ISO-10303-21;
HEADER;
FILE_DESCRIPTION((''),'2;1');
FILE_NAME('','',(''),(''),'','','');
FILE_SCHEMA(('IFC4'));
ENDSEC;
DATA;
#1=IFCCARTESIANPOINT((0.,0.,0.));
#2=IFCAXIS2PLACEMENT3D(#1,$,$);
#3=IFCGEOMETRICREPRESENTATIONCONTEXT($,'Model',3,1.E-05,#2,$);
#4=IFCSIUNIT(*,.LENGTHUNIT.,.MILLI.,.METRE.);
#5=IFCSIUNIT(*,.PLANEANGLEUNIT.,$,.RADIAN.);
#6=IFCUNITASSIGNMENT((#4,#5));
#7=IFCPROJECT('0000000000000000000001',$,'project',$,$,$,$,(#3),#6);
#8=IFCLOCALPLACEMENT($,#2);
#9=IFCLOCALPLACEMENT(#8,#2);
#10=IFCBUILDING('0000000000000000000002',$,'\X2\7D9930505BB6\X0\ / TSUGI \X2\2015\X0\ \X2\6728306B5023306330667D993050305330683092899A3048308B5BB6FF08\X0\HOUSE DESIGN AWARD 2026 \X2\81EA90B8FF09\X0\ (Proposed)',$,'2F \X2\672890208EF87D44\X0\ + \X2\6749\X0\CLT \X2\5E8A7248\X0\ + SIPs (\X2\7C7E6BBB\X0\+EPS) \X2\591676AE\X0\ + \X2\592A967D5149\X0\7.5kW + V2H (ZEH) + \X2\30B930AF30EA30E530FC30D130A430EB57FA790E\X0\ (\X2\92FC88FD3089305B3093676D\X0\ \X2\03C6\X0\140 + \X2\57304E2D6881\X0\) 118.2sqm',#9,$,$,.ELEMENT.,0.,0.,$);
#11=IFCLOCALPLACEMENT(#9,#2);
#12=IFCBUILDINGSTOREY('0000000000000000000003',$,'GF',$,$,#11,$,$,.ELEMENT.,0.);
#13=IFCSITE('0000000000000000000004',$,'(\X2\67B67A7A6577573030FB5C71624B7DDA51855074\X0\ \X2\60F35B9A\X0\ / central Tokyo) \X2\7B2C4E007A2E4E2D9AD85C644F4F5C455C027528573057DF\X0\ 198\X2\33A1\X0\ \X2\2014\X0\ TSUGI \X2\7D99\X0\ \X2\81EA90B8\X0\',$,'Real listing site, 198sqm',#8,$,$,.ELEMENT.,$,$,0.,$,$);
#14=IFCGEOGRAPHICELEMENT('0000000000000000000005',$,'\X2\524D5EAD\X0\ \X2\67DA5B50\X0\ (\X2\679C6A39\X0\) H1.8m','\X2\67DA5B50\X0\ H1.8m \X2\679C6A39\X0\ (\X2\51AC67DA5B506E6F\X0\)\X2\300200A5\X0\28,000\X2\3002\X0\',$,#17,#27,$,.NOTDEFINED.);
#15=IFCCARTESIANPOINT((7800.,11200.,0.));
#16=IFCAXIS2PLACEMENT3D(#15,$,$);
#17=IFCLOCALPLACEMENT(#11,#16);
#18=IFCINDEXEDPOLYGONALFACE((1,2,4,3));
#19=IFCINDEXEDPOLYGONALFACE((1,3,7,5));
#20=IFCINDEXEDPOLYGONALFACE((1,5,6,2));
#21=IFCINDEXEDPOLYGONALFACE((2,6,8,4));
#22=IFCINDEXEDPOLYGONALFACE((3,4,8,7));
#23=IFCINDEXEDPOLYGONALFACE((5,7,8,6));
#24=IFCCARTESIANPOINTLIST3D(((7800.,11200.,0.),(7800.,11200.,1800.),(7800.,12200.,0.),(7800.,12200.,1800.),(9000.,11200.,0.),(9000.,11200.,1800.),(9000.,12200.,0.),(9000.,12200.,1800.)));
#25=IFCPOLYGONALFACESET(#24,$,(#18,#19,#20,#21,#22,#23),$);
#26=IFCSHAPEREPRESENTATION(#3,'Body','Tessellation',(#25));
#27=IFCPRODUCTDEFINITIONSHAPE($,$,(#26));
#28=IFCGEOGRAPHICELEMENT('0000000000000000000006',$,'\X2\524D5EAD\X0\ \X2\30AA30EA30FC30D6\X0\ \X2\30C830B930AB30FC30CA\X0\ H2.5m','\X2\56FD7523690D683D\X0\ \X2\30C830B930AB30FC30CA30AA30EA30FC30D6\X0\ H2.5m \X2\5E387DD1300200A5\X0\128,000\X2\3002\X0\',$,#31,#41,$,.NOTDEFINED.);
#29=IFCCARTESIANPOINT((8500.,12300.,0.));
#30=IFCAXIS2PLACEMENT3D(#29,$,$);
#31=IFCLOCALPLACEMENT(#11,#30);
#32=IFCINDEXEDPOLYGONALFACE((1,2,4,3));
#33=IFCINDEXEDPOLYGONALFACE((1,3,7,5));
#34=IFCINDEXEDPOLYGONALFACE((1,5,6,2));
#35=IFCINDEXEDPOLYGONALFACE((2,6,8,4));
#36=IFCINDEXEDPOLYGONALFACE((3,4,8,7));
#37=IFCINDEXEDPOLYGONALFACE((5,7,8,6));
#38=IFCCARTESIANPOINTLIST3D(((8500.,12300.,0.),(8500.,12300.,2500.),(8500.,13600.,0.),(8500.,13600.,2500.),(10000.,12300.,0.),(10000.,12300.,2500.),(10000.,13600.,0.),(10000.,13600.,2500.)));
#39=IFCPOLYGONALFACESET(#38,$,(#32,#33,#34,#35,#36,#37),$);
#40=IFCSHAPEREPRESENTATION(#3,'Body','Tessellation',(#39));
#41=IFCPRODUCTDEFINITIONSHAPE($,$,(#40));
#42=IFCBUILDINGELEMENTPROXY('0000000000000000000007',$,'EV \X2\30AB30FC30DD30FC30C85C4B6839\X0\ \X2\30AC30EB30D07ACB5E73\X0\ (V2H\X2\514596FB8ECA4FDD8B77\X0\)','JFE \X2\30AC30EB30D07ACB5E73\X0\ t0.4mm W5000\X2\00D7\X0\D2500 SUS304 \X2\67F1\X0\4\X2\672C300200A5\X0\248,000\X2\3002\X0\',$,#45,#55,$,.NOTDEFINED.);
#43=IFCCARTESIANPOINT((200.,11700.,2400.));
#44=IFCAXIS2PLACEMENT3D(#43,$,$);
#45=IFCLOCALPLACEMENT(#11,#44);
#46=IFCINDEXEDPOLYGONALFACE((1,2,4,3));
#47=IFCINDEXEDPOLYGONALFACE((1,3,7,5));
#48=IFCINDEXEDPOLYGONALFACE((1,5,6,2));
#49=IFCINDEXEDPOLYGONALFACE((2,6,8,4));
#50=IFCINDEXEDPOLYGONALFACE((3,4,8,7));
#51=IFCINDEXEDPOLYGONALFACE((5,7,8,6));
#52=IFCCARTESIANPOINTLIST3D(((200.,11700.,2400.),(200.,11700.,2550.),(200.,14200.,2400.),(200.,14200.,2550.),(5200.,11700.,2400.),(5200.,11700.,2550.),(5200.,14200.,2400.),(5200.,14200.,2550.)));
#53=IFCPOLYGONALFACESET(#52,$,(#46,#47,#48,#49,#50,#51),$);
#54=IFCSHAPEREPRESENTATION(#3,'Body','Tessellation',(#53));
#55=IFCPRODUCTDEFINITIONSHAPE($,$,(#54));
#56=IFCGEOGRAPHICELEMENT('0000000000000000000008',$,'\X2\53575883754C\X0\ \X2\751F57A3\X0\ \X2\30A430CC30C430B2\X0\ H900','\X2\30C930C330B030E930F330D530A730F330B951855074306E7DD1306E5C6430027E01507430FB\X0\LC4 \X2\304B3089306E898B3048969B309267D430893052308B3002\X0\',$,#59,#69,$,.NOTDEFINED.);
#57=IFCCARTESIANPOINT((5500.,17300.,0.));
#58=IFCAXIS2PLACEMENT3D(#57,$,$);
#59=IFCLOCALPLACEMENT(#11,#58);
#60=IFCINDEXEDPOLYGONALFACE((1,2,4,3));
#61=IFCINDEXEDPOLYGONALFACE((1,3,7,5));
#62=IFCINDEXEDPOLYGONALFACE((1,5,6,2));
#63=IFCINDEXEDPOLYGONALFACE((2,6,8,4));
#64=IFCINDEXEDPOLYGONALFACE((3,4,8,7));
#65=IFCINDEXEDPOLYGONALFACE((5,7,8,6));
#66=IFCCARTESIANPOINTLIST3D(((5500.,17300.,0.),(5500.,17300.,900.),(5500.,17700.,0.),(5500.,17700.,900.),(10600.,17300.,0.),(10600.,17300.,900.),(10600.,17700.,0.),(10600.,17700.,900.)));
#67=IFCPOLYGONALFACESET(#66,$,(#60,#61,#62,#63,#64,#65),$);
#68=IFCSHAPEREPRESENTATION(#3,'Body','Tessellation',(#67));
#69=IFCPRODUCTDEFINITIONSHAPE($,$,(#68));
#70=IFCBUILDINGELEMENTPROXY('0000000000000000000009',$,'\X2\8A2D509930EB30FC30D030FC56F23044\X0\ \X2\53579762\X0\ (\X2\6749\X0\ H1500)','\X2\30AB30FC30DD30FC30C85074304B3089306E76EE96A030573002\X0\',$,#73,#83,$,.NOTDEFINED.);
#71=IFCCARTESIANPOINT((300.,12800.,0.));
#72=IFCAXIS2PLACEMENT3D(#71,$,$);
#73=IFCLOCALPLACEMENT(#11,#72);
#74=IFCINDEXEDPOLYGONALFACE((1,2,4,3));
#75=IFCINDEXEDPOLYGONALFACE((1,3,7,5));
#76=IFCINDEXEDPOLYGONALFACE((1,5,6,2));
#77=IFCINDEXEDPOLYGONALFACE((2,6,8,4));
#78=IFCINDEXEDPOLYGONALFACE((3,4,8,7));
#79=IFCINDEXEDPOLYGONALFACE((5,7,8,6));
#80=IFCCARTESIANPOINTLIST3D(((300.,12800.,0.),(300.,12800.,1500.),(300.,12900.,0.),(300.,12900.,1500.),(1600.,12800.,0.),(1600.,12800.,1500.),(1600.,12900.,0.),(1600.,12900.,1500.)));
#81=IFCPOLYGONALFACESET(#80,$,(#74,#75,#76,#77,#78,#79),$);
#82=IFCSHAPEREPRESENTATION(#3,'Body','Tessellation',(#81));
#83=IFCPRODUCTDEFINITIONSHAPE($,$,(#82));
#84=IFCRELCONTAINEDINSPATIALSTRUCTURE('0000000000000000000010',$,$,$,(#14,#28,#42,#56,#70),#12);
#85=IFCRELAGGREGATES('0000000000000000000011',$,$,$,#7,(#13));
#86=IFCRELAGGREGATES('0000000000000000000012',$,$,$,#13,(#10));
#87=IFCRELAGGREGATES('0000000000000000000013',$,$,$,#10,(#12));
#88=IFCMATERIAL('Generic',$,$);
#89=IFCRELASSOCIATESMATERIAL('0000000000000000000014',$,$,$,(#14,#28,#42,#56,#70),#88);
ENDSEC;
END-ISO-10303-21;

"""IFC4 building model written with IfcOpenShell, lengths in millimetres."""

from ifc_helpers import new_model, si_unit, frame, frame_2d, origin, place, context, project, spatial, rectangle, extrude, material, element, save


model = new_model("IFC4")

# Units and contexts
model_context = context("Model", 3, precision=1e-05, world=origin())
ifc_project = project(units=[si_unit("LENGTHUNIT", "METRE", prefix="MILLI"), si_unit("PLANEANGLEUNIT", "RADIAN")], contexts=[model_context])

# Site, building, storey
site_placement = place(None, origin())
site = spatial("IfcSite", under=ifc_project, at=site_placement, Name="(架空敷地・山手線内側 想定 / central Tokyo) 第一種中高層住居専用地域 198㎡ — TSUGI 継 自邸", ObjectType="Real listing site, 198sqm", CompositionType="ELEMENT", RefElevation=0.0)
building_placement = place(site_placement, origin())
building = spatial("IfcBuilding", under=site, at=building_placement, Name="継ぐ家 / TSUGI ― 木に倣って継ぐことを覚える家（HOUSE DESIGN AWARD 2026 自邸） (Proposed)", ObjectType="2F 木造軸組 + 杉CLT 床版 + SIPs (籾殻+EPS) 外皮 + 太陽光7.5kW + V2H (ZEH) + スクリューパイル基礎 (鋼製らせん杭 φ140 + 地中梁) 118.2sqm", CompositionType="ELEMENT", ElevationOfRefHeight=0.0, ElevationOfTerrain=0.0)
storey_placement = place(building_placement, origin())
storey = spatial("IfcBuildingStorey", under=building, at=storey_placement, Name="GF", CompositionType="ELEMENT", Elevation=0.0)

# Shared definitions
ifc_material_1 = material(Name="Generic")

# Geographic elements
geographic_element_1_placement = place(storey_placement, frame((7800.0, 11200.0, 0.0)))
element("IfcGeographicElement", 1, at=geographic_element_1_placement, inside=storey, material=ifc_material_1, Name="前庭 柚子 (果樹) H1.8m", Description="柚子 H1.8m 果樹 (冬柚子湯)。¥28,000。", PredefinedType="NOTDEFINED", context=model_context, shape_type="SweptSolid", body=[
    extrude(rectangle(XDim=1200.0, YDim=1000.0, at=frame_2d((600.0, 500.0))), frame((7800.0, 11200.0, 0.0)), (0.0, 0.0, 1.0), 1800.0),
])
geographic_element_2_placement = place(storey_placement, frame((8500.0, 12300.0, 0.0)))
element("IfcGeographicElement", 2, at=geographic_element_2_placement, inside=storey, material=ifc_material_1, Name="前庭 オリーブ トスカーナ H2.5m", Description="国産植栽 トスカーナオリーブ H2.5m 常緑。¥128,000。", PredefinedType="NOTDEFINED", context=model_context, shape_type="SweptSolid", body=[
    extrude(rectangle(XDim=1500.0, YDim=1300.0, at=frame_2d((750.0, 650.0))), frame((8500.0, 12300.0, 0.0)), (0.0, 0.0, 1.0), 2500.0),
])

# Building element proxy
proxy_1_placement = place(storey_placement, frame((200.0, 11700.0, 2400.0)))
element("IfcBuildingElementProxy", 3, at=proxy_1_placement, inside=storey, material=ifc_material_1, Name="EV カーポート屋根 ガルバ立平 (V2H充電車保護)", Description="JFE ガルバ立平 t0.4mm W5000×D2500 SUS304 柱4本。¥248,000。", PredefinedType="NOTDEFINED", context=model_context, shape_type="SweptSolid", body=[
    extrude(rectangle(XDim=5000.0, YDim=2500.0, at=frame_2d((2500.0, 1250.0))), frame((200.0, 11700.0, 2400.0)), (0.0, 0.0, 1.0), 150.0),
])

# Geographic element
geographic_element_3_placement = place(storey_placement, frame((5500.0, 17300.0, 0.0)))
element("IfcGeographicElement", 4, at=geographic_element_3_placement, inside=storey, material=ifc_material_1, Name="南境界 生垣 イヌツゲ H900", Description="ドッグランフェンス内側の緑の層。縁側・LC4 からの見え際を柔らげる。", PredefinedType="NOTDEFINED", context=model_context, shape_type="SweptSolid", body=[
    extrude(rectangle(XDim=5100.0, YDim=400.0, at=frame_2d((2550.0, 200.0))), frame((5500.0, 17300.0, 0.0)), (0.0, 0.0, 1.0), 900.0),
])

# Building element proxy
proxy_2_placement = place(storey_placement, frame((300.0, 12800.0, 0.0)))
element("IfcBuildingElementProxy", 5, at=proxy_2_placement, inside=storey, material=ifc_material_1, Name="設備ルーバー囲い 南面 (杉 H1500)", Description="カーポート側からの目隠し。", PredefinedType="NOTDEFINED", context=model_context, shape_type="SweptSolid", body=[
    extrude(rectangle(XDim=1300.0, YDim=100.0, at=frame_2d((650.0, 50.0))), frame((300.0, 12800.0, 0.0)), (0.0, 0.0, 1.0), 1500.0),
])

save(model, "model.ifc")
